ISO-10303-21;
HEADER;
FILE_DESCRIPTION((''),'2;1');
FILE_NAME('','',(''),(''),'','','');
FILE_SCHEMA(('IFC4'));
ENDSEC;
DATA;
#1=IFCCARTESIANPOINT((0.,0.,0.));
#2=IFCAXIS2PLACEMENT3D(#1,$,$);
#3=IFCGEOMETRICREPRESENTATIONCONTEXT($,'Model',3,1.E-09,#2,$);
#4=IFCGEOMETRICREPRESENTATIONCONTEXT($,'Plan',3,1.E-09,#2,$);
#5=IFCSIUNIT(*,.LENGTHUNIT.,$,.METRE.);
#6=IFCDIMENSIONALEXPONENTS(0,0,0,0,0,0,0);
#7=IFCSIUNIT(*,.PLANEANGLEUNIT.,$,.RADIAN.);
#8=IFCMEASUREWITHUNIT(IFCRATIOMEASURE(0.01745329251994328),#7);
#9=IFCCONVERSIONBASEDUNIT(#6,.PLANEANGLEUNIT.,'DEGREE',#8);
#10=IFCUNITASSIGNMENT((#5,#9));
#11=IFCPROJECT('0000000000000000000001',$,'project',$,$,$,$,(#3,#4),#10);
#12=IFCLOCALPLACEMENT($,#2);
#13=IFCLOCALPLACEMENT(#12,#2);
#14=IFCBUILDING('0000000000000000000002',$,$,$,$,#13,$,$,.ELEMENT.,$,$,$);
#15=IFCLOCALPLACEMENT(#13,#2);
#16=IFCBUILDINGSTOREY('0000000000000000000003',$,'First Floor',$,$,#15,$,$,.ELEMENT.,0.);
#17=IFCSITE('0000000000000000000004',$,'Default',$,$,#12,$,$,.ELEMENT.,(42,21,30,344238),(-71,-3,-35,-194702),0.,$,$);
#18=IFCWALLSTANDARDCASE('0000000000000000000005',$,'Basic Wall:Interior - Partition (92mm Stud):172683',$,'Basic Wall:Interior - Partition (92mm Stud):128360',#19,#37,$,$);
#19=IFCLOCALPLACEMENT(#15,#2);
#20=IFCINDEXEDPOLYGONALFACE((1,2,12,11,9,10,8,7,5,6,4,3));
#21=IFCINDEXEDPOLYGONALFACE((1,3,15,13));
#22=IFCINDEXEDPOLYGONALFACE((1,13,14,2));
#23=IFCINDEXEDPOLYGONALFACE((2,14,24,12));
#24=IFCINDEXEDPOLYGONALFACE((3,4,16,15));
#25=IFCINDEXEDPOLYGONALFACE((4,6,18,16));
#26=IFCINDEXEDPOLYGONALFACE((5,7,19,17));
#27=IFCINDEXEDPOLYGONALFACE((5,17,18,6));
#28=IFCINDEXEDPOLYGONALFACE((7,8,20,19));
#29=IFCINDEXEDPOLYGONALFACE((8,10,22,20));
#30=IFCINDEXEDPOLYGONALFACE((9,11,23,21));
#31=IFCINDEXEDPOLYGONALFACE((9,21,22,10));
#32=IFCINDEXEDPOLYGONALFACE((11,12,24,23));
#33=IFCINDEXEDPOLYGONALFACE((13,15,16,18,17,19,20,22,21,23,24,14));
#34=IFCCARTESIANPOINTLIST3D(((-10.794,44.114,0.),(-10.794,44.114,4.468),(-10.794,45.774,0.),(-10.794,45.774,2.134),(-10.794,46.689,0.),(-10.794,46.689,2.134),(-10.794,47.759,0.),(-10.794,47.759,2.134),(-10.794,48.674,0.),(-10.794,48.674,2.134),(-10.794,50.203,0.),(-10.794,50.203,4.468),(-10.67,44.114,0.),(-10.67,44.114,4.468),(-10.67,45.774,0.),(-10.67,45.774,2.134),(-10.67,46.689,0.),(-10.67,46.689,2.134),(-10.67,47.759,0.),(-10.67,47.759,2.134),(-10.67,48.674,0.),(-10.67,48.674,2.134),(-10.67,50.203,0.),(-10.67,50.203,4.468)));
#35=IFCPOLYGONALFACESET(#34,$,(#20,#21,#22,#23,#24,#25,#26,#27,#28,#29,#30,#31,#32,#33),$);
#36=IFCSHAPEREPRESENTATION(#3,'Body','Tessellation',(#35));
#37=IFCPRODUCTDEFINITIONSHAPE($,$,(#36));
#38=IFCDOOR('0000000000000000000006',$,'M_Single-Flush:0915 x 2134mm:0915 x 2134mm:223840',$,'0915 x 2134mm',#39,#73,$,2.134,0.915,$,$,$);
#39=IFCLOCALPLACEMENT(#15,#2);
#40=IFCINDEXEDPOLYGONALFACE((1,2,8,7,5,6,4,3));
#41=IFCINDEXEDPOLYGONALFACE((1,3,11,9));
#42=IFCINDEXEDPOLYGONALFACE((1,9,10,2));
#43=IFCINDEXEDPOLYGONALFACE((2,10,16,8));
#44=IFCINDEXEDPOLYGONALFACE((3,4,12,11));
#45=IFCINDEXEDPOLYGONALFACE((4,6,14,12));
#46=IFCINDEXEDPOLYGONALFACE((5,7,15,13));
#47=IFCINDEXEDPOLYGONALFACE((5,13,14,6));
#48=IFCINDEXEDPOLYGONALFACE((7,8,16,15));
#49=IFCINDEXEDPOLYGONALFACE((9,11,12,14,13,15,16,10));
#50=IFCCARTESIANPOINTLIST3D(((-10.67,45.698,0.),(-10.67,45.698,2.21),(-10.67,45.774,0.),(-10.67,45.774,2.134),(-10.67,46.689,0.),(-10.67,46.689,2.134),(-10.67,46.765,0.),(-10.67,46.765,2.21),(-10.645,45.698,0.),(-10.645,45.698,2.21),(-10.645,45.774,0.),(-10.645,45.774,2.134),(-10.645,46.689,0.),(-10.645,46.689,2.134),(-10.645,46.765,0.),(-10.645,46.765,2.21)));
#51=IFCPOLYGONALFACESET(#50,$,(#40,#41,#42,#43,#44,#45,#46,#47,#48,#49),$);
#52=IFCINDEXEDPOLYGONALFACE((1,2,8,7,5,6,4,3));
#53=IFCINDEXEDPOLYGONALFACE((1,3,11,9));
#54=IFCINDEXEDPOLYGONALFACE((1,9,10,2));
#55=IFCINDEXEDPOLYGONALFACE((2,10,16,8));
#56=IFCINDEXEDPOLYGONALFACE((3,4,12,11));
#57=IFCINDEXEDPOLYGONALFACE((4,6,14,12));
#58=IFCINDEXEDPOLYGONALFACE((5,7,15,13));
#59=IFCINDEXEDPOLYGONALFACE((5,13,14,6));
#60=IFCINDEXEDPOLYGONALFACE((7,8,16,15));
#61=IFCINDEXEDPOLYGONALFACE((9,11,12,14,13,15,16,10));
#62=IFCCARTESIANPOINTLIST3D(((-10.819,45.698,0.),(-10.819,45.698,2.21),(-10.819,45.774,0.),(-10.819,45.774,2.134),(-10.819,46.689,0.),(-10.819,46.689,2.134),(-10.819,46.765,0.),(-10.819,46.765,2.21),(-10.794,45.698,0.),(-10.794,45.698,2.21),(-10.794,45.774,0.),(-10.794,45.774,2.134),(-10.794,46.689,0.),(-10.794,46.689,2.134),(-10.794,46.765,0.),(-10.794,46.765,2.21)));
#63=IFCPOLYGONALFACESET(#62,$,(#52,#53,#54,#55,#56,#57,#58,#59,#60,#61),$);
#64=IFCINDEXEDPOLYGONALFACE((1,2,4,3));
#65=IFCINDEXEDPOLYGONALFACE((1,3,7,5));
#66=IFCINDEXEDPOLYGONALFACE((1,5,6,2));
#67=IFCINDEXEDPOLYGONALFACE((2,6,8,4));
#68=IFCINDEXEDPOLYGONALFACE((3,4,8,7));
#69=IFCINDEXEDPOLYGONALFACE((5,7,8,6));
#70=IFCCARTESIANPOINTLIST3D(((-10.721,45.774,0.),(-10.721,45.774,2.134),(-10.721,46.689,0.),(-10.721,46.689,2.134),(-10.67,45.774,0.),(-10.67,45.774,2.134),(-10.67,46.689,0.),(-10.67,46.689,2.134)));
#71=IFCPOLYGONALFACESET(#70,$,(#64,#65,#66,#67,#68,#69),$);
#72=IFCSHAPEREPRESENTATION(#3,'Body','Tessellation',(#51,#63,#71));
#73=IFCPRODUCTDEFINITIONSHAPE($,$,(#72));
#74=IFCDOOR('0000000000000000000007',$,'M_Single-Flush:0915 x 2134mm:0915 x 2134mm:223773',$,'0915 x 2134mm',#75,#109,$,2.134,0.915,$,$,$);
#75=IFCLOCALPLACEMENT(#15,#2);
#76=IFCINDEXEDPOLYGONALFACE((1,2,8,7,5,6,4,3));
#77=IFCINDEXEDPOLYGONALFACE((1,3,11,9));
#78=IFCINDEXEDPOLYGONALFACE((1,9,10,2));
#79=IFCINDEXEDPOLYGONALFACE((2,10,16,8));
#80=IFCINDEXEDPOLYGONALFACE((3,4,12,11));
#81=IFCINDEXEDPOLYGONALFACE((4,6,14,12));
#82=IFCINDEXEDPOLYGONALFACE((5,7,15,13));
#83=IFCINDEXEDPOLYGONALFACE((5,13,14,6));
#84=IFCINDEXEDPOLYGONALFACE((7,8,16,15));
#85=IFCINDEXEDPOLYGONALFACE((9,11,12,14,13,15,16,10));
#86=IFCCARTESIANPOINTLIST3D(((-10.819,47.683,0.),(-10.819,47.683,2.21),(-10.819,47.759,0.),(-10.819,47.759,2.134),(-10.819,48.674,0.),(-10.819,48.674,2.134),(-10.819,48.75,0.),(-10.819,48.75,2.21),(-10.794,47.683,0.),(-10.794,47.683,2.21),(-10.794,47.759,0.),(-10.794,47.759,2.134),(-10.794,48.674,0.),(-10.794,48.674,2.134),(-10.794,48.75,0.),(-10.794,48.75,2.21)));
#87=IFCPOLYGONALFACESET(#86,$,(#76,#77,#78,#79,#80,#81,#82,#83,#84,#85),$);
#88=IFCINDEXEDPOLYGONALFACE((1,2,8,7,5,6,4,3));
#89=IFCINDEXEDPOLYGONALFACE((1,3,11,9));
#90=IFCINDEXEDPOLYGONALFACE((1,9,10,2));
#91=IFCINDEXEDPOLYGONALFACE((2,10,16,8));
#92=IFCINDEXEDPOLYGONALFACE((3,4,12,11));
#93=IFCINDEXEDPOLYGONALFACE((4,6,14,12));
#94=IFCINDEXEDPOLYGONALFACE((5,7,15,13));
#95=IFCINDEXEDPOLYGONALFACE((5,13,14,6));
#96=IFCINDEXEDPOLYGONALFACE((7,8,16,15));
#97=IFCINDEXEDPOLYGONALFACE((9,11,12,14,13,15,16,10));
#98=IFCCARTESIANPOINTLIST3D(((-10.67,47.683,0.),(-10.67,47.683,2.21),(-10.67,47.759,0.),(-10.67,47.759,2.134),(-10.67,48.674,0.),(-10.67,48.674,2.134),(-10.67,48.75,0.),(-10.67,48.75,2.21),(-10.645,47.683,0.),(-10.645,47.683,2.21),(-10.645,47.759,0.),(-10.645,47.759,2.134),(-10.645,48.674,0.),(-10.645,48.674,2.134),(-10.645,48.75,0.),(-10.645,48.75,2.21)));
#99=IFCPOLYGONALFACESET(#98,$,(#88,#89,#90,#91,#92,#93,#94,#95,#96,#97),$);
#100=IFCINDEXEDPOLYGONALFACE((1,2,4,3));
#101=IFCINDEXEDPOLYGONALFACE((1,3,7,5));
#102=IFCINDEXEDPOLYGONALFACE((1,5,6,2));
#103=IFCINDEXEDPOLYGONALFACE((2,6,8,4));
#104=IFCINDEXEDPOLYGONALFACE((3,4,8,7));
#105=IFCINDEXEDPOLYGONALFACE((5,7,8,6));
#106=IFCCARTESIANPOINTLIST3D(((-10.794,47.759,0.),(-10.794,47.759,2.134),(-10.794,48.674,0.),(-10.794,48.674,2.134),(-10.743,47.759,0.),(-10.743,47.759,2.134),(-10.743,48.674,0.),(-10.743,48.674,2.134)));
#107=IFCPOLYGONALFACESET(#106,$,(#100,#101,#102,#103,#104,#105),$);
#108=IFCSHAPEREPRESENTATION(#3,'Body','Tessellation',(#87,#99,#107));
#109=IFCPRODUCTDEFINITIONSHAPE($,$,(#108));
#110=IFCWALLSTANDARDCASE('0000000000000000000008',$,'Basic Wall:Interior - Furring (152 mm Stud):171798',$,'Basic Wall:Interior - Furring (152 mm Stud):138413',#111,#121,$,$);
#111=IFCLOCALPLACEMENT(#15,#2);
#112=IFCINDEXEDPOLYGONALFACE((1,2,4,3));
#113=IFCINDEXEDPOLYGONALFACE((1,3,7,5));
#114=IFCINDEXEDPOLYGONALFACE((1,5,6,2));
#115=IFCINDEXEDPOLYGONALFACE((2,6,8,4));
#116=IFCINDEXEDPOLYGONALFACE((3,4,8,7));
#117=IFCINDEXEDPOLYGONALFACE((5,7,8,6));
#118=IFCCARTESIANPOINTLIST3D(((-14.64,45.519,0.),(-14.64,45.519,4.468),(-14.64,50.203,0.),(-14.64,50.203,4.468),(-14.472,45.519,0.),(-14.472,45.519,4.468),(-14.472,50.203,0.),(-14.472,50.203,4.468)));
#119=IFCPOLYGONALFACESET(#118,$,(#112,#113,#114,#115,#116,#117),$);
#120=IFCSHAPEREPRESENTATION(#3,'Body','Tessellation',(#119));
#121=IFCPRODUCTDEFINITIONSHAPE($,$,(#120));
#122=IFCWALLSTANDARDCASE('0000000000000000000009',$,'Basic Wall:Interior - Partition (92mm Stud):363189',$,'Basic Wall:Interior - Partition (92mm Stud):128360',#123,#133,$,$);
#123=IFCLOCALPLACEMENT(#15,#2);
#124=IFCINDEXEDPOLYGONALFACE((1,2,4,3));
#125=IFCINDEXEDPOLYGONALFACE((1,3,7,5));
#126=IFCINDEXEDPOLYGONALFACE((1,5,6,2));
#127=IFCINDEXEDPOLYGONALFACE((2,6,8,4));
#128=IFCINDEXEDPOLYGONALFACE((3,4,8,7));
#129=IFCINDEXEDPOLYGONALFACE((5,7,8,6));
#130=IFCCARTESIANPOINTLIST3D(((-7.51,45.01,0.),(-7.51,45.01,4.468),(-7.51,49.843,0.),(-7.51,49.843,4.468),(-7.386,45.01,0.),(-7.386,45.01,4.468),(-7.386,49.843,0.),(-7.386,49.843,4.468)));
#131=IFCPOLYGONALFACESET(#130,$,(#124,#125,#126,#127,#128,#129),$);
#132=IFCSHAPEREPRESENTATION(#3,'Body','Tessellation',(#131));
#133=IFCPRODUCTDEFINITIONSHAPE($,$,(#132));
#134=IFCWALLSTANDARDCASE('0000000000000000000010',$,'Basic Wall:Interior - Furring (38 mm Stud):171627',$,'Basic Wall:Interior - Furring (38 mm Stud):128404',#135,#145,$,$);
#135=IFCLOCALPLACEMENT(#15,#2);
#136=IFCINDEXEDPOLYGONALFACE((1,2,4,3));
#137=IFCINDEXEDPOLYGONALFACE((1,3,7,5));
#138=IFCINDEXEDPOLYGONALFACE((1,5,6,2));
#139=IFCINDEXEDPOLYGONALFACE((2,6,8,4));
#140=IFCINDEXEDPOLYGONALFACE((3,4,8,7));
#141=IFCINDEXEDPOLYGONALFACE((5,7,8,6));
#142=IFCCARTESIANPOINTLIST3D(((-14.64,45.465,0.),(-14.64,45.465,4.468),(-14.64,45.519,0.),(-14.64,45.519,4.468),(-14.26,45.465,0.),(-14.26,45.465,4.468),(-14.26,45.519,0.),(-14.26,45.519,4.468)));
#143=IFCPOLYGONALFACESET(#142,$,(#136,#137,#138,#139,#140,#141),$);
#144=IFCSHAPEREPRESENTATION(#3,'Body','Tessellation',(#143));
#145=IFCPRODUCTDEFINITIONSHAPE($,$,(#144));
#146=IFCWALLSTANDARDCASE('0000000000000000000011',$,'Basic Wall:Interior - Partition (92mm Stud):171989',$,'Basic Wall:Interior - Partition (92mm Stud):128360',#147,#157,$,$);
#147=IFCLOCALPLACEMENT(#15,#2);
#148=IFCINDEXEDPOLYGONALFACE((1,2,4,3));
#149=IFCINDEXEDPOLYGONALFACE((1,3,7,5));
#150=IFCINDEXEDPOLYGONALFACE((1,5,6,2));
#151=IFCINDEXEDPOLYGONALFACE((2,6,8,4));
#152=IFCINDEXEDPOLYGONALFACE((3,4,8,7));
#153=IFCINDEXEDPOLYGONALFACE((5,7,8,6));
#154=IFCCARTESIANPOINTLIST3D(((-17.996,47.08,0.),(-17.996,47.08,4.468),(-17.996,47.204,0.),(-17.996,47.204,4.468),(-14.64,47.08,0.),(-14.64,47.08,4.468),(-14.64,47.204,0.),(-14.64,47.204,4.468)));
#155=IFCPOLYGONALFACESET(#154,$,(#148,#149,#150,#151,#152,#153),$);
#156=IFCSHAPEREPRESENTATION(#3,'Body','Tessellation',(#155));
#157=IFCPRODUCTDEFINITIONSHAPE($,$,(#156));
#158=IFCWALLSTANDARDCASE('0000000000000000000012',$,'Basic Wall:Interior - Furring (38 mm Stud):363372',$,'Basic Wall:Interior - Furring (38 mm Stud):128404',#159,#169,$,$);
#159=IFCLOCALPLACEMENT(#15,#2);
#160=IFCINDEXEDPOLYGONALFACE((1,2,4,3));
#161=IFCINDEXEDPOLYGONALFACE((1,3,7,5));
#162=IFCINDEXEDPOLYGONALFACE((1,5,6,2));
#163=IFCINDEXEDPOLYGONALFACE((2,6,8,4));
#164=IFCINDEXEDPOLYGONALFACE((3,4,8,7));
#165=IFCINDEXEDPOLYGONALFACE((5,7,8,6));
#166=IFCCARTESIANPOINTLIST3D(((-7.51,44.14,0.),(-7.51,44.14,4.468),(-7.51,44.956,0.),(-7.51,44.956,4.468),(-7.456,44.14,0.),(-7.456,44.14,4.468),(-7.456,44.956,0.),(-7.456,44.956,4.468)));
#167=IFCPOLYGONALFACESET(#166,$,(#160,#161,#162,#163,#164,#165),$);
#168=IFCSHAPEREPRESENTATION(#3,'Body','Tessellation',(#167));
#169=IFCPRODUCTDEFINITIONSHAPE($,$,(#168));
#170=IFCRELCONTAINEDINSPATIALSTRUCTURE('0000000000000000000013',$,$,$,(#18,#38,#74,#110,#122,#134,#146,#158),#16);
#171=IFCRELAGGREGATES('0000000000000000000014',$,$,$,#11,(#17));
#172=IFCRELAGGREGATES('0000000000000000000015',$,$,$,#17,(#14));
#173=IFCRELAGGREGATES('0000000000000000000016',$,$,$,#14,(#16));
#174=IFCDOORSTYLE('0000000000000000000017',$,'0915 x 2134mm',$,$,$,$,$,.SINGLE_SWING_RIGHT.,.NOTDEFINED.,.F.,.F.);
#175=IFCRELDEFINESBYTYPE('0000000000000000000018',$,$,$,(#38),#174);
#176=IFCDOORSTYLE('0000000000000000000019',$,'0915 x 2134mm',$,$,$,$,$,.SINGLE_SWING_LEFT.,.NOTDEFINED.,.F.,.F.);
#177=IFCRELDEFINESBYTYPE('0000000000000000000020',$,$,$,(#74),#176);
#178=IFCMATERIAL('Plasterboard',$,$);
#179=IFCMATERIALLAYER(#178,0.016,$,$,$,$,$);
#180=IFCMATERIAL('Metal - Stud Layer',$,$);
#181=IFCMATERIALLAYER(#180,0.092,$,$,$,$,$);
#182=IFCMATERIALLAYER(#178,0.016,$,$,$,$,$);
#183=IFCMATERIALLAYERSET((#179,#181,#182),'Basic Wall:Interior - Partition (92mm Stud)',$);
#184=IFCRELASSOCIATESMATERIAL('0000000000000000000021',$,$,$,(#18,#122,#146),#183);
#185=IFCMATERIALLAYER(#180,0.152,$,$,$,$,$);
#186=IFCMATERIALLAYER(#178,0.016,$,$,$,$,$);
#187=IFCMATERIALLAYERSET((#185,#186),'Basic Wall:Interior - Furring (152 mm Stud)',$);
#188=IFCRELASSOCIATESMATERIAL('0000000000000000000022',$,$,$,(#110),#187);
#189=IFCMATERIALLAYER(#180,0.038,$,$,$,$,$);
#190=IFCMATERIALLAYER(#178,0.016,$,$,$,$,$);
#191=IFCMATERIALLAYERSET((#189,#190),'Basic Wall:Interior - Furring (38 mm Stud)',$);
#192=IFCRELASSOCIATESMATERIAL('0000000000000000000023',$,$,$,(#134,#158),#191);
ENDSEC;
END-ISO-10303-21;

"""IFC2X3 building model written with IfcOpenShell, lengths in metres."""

from ifc_helpers import new_model, entity, si_unit, converted_unit, frame, frame_2d, origin, origin_2d_with_axis, place, context, project, spatial, polyline, rectangle, outline, extrude, source, transform, mapped, material, layer, layer_set, layer_usage, type_object, type_shapes, element, fill, save


model = new_model("IFC2X3")

# Units and contexts
model_context = context("Model", 3, precision=1e-09, world=origin())
plan_context = context("Plan", 3, precision=1e-09, world=origin())
ifc_project = project(units=[si_unit("LENGTHUNIT", "METRE"), converted_unit("PLANEANGLEUNIT", "DEGREE", entity("IfcRatioMeasure", 0.01745329251994328), si_unit("PLANEANGLEUNIT", "RADIAN"), dimensions=[0, 0, 0, 0, 0, 0, 0])], contexts=[model_context, plan_context])

# Site, building, storey
site_placement = place(None, origin())
site = spatial("IfcSite", under=ifc_project, at=site_placement, Name="Default", CompositionType="ELEMENT", RefLatitude=(42, 21, 30, 344238), RefLongitude=(-71, -3, -35, -194702), RefElevation=0.0)
building_placement = place(site_placement, origin())
building = spatial("IfcBuilding", under=site, at=building_placement, CompositionType="ELEMENT")
storey_placement = place(building_placement, origin())
storey = spatial("IfcBuildingStorey", under=building, at=storey_placement, Name="First Floor", CompositionType="ELEMENT", Elevation=0.0)

# Wall, openings, doors
ifc_material_1 = material(Name="Plasterboard")
ifc_layer_1 = layer(ifc_material_1, 0.016)
ifc_material_2 = material(Name="Metal - Stud Layer")
ifc_layer_2 = layer(ifc_material_2, 0.092)
ifc_layer_3 = layer(ifc_material_1, 0.016)
ifc_layer_set_1 = layer_set([ifc_layer_1, ifc_layer_2, ifc_layer_3], Name="Basic Wall:Interior - Partition (92mm Stud)")
ifc_layer_usage_1 = layer_usage(ifc_layer_set_1, "AXIS2", "NEGATIVE", 0.062)
wall_1_placement = place(storey_placement, frame((-10.732, 50.203, 0.0), z_axis=(0.0, 0.0, 1.0), x_axis=(0.0, -1.0, 0.0)))
wall_1 = element("IfcWallStandardCase", 1, at=wall_1_placement, inside=storey, material=ifc_layer_usage_1, Name="Basic Wall:Interior - Partition (92mm Stud):172683", ObjectType="Basic Wall:Interior - Partition (92mm Stud):128360", context=model_context, shape_type="SweptSolid", body=[
    extrude(rectangle(XDim=6.089, YDim=0.124, at=frame_2d((3.0445, 0.0), x_axis=(-1.0, 0.0))), origin(), (0.0, 0.0, 1.0), 4.468),
])
opening_1_placement = place(wall_1_placement, frame((2.444, 0.062, 0.0)))
opening_1 = element("IfcOpeningElement", 2, at=opening_1_placement, cuts=wall_1, ObjectType="Opening", context=model_context, shape_type="SweptSolid", body=[
    extrude(rectangle(XDim=0.915, YDim=2.134, at=frame_2d((1.067, 0.4575), x_axis=(0.0, -1.0))), frame((0.0, 0.0, 0.0), z_axis=(0.0, -1.0, 0.0), x_axis=(0.0, 0.0, 1.0)), (0.0, 0.0, 1.0), 0.124),
])
opening_2_placement = place(wall_1_placement, frame((3.514, -0.062, 0.0)))
opening_2 = element("IfcOpeningElement", 3, at=opening_2_placement, cuts=wall_1, ObjectType="Opening", context=model_context, shape_type="SweptSolid", body=[
    extrude(rectangle(XDim=0.915, YDim=2.134, at=frame_2d((1.067, 0.4575), x_axis=(0.0, 1.0))), frame((0.0, 0.0, 0.0), z_axis=(0.0, 1.0, 0.0), x_axis=(0.0, 0.0, 1.0)), (0.0, 0.0, 1.0), 0.124),
])
door_style_1 = type_object("IfcDoorStyle", Name="0915 x 2134mm", ConstructionType="NOTDEFINED", OperationType="SINGLE_SWING_RIGHT", ParameterTakesPrecedence=False, Sizeable=False)
shared_shape_1 = source(origin(), model_context, "Body", "SweptSolid", [
    extrude(outline(polyline([(-0.5335, -1.124), (0.5335, -1.124), (0.5335, 1.086), (0.4575, 1.086), (0.4575, -1.048), (-0.4575, -1.048), (-0.4575, 1.086), (-0.5335, 1.086), (-0.5335, -1.124)])), frame((0.4575, 0.124, 1.086), z_axis=(0.0, 1.0, 0.0), x_axis=(1.0, 0.0, 0.0)), (0.0, 0.0, 1.0), 0.025),
    extrude(outline(polyline([(-1.124, -0.5335), (1.086, -0.5335), (1.086, -0.4575), (-1.048, -0.4575), (-1.048, 0.4575), (1.086, 0.4575), (1.086, 0.5335), (-1.124, 0.5335), (-1.124, -0.5335)])), frame((0.4575, -0.025, 1.086), z_axis=(0.0, 1.0, 0.0), x_axis=(0.0, 0.0, -1.0)), (0.0, 0.0, 1.0), 0.025),
    extrude(rectangle(XDim=0.051, YDim=0.915, at=origin_2d_with_axis()), frame((0.4575, 0.0985, 0.0), z_axis=(0.0, 0.0, 1.0), x_axis=(0.0, 1.0, 0.0)), (0.0, 0.0, 1.0), 2.134),
])
type_shapes(door_style_1, [shared_shape_1])
door_1_placement = place(opening_2_placement, origin())
door_1 = element("IfcDoor", 4, at=door_1_placement, inside=storey, type_object=door_style_1, Name="M_Single-Flush:0915 x 2134mm:0915 x 2134mm:223840", ObjectType="0915 x 2134mm", OverallHeight=2.134, OverallWidth=0.915, context=model_context, shape_type="MappedRepresentation", body=[
    mapped(shared_shape_1, transform((0.0, 0.0, 0.0), scale=1.0)),
])
fill(opening_2, door_1)
door_style_2 = type_object("IfcDoorStyle", Name="0915 x 2134mm", ConstructionType="NOTDEFINED", OperationType="SINGLE_SWING_LEFT", ParameterTakesPrecedence=False, Sizeable=False)
shared_shape_2 = source(origin(), model_context, "Body", "SweptSolid", [
    extrude(outline(polyline([(-0.5335, -1.124), (0.5335, -1.124), (0.5335, 1.086), (0.4575, 1.086), (0.4575, -1.048), (-0.4575, -1.048), (-0.4575, 1.086), (-0.5335, 1.086), (-0.5335, -1.124)])), frame((0.4575, 0.149, 1.086), z_axis=(0.0, -1.0, 0.0), x_axis=(-1.0, 0.0, 0.0)), (0.0, 0.0, 1.0), 0.025),
    extrude(outline(polyline([(-1.124, -0.5335), (1.086, -0.5335), (1.086, -0.4575), (-1.048, -0.4575), (-1.048, 0.4575), (1.086, 0.4575), (1.086, 0.5335), (-1.124, 0.5335), (-1.124, -0.5335)])), frame((0.4575, 0.0, 1.086), z_axis=(0.0, -1.0, 0.0), x_axis=(0.0, 0.0, -1.0)), (0.0, 0.0, 1.0), 0.025),
    extrude(rectangle(XDim=0.915, YDim=0.051, at=origin_2d_with_axis()), frame((0.4575, 0.0985, 0.0)), (0.0, 0.0, 1.0), 2.134),
])
type_shapes(door_style_2, [shared_shape_2])
door_2_placement = place(opening_1_placement, frame((0.0, 0.0, 0.0), z_axis=(0.0, 0.0, 1.0), x_axis=(-1.0, 0.0, 0.0)))
door_2 = element("IfcDoor", 5, at=door_2_placement, inside=storey, type_object=door_style_2, Name="M_Single-Flush:0915 x 2134mm:0915 x 2134mm:223773", ObjectType="0915 x 2134mm", OverallHeight=2.134, OverallWidth=0.915, context=model_context, shape_type="MappedRepresentation", body=[
    mapped(shared_shape_2, transform((0.0, 0.0, 0.0), scale=1.0)),
])
fill(opening_1, door_2)

# Walls
ifc_layer_4 = layer(ifc_material_2, 0.152)
ifc_layer_5 = layer(ifc_material_1, 0.016)
ifc_layer_set_2 = layer_set([ifc_layer_4, ifc_layer_5], Name="Basic Wall:Interior - Furring (152 mm Stud)")
ifc_layer_usage_2 = layer_usage(ifc_layer_set_2, "AXIS2", "POSITIVE", -0.084)
wall_2_placement = place(storey_placement, frame((-14.556, 45.519, 0.0), z_axis=(0.0, 0.0, 1.0), x_axis=(0.0, 1.0, 0.0)))
element("IfcWallStandardCase", 6, at=wall_2_placement, inside=storey, material=ifc_layer_usage_2, Name="Basic Wall:Interior - Furring (152 mm Stud):171798", ObjectType="Basic Wall:Interior - Furring (152 mm Stud):138413", context=model_context, shape_type="SweptSolid", body=[
    extrude(rectangle(XDim=4.684, YDim=0.168, at=frame_2d((2.342, 0.0), x_axis=(-1.0, 0.0))), origin(), (0.0, 0.0, 1.0), 4.468),
])
wall_3_placement = place(storey_placement, frame((-7.448, 45.01, 0.0), z_axis=(0.0, 0.0, 1.0), x_axis=(0.0, 1.0, 0.0)))
element("IfcWallStandardCase", 7, at=wall_3_placement, inside=storey, material=ifc_layer_usage_1, Name="Basic Wall:Interior - Partition (92mm Stud):363189", ObjectType="Basic Wall:Interior - Partition (92mm Stud):128360", context=model_context, shape_type="SweptSolid", body=[
    extrude(rectangle(XDim=4.833, YDim=0.124, at=frame_2d((2.4165, 0.0), x_axis=(-1.0, 0.0))), origin(), (0.0, 0.0, 1.0), 4.468),
])
ifc_layer_6 = layer(ifc_material_2, 0.038)
ifc_layer_7 = layer(ifc_material_1, 0.016)
ifc_layer_set_3 = layer_set([ifc_layer_6, ifc_layer_7], Name="Basic Wall:Interior - Furring (38 mm Stud)")
ifc_layer_usage_3 = layer_usage(ifc_layer_set_3, "AXIS2", "POSITIVE", -0.027)
wall_4_placement = place(storey_placement, frame((-14.26, 45.492, 0.0), z_axis=(0.0, 0.0, 1.0), x_axis=(-1.0, 0.0, 0.0)))
element("IfcWallStandardCase", 8, at=wall_4_placement, inside=storey, material=ifc_layer_usage_3, Name="Basic Wall:Interior - Furring (38 mm Stud):171627", ObjectType="Basic Wall:Interior - Furring (38 mm Stud):128404", context=model_context, shape_type="SweptSolid", body=[
    extrude(rectangle(XDim=0.38, YDim=0.054, at=frame_2d((0.19, 0.0), x_axis=(-1.0, 0.0))), origin(), (0.0, 0.0, 1.0), 4.468),
])
wall_5_placement = place(storey_placement, frame((-14.64, 47.142, 0.0), z_axis=(0.0, 0.0, 1.0), x_axis=(-1.0, 0.0, 0.0)))
element("IfcWallStandardCase", 9, at=wall_5_placement, inside=storey, material=ifc_layer_usage_1, Name="Basic Wall:Interior - Partition (92mm Stud):171989", ObjectType="Basic Wall:Interior - Partition (92mm Stud):128360", context=model_context, shape_type="SweptSolid", body=[
    extrude(rectangle(XDim=3.356, YDim=0.124, at=frame_2d((1.678, 0.0), x_axis=(-1.0, 0.0))), origin(), (0.0, 0.0, 1.0), 4.468),
])
ifc_layer_usage_4 = layer_usage(ifc_layer_set_3, "AXIS2", "NEGATIVE", 0.027)
wall_6_placement = place(storey_placement, frame((-7.483, 44.956, 0.0), z_axis=(0.0, 0.0, 1.0), x_axis=(0.0, -1.0, 0.0)))
element("IfcWallStandardCase", 10, at=wall_6_placement, inside=storey, material=ifc_layer_usage_4, Name="Basic Wall:Interior - Furring (38 mm Stud):363372", ObjectType="Basic Wall:Interior - Furring (38 mm Stud):128404", context=model_context, shape_type="SweptSolid", body=[
    extrude(rectangle(XDim=0.816, YDim=0.054, at=frame_2d((0.408, 0.0), x_axis=(-1.0, 0.0))), origin(), (0.0, 0.0, 1.0), 4.468),
])

save(model, "model.ifc")
